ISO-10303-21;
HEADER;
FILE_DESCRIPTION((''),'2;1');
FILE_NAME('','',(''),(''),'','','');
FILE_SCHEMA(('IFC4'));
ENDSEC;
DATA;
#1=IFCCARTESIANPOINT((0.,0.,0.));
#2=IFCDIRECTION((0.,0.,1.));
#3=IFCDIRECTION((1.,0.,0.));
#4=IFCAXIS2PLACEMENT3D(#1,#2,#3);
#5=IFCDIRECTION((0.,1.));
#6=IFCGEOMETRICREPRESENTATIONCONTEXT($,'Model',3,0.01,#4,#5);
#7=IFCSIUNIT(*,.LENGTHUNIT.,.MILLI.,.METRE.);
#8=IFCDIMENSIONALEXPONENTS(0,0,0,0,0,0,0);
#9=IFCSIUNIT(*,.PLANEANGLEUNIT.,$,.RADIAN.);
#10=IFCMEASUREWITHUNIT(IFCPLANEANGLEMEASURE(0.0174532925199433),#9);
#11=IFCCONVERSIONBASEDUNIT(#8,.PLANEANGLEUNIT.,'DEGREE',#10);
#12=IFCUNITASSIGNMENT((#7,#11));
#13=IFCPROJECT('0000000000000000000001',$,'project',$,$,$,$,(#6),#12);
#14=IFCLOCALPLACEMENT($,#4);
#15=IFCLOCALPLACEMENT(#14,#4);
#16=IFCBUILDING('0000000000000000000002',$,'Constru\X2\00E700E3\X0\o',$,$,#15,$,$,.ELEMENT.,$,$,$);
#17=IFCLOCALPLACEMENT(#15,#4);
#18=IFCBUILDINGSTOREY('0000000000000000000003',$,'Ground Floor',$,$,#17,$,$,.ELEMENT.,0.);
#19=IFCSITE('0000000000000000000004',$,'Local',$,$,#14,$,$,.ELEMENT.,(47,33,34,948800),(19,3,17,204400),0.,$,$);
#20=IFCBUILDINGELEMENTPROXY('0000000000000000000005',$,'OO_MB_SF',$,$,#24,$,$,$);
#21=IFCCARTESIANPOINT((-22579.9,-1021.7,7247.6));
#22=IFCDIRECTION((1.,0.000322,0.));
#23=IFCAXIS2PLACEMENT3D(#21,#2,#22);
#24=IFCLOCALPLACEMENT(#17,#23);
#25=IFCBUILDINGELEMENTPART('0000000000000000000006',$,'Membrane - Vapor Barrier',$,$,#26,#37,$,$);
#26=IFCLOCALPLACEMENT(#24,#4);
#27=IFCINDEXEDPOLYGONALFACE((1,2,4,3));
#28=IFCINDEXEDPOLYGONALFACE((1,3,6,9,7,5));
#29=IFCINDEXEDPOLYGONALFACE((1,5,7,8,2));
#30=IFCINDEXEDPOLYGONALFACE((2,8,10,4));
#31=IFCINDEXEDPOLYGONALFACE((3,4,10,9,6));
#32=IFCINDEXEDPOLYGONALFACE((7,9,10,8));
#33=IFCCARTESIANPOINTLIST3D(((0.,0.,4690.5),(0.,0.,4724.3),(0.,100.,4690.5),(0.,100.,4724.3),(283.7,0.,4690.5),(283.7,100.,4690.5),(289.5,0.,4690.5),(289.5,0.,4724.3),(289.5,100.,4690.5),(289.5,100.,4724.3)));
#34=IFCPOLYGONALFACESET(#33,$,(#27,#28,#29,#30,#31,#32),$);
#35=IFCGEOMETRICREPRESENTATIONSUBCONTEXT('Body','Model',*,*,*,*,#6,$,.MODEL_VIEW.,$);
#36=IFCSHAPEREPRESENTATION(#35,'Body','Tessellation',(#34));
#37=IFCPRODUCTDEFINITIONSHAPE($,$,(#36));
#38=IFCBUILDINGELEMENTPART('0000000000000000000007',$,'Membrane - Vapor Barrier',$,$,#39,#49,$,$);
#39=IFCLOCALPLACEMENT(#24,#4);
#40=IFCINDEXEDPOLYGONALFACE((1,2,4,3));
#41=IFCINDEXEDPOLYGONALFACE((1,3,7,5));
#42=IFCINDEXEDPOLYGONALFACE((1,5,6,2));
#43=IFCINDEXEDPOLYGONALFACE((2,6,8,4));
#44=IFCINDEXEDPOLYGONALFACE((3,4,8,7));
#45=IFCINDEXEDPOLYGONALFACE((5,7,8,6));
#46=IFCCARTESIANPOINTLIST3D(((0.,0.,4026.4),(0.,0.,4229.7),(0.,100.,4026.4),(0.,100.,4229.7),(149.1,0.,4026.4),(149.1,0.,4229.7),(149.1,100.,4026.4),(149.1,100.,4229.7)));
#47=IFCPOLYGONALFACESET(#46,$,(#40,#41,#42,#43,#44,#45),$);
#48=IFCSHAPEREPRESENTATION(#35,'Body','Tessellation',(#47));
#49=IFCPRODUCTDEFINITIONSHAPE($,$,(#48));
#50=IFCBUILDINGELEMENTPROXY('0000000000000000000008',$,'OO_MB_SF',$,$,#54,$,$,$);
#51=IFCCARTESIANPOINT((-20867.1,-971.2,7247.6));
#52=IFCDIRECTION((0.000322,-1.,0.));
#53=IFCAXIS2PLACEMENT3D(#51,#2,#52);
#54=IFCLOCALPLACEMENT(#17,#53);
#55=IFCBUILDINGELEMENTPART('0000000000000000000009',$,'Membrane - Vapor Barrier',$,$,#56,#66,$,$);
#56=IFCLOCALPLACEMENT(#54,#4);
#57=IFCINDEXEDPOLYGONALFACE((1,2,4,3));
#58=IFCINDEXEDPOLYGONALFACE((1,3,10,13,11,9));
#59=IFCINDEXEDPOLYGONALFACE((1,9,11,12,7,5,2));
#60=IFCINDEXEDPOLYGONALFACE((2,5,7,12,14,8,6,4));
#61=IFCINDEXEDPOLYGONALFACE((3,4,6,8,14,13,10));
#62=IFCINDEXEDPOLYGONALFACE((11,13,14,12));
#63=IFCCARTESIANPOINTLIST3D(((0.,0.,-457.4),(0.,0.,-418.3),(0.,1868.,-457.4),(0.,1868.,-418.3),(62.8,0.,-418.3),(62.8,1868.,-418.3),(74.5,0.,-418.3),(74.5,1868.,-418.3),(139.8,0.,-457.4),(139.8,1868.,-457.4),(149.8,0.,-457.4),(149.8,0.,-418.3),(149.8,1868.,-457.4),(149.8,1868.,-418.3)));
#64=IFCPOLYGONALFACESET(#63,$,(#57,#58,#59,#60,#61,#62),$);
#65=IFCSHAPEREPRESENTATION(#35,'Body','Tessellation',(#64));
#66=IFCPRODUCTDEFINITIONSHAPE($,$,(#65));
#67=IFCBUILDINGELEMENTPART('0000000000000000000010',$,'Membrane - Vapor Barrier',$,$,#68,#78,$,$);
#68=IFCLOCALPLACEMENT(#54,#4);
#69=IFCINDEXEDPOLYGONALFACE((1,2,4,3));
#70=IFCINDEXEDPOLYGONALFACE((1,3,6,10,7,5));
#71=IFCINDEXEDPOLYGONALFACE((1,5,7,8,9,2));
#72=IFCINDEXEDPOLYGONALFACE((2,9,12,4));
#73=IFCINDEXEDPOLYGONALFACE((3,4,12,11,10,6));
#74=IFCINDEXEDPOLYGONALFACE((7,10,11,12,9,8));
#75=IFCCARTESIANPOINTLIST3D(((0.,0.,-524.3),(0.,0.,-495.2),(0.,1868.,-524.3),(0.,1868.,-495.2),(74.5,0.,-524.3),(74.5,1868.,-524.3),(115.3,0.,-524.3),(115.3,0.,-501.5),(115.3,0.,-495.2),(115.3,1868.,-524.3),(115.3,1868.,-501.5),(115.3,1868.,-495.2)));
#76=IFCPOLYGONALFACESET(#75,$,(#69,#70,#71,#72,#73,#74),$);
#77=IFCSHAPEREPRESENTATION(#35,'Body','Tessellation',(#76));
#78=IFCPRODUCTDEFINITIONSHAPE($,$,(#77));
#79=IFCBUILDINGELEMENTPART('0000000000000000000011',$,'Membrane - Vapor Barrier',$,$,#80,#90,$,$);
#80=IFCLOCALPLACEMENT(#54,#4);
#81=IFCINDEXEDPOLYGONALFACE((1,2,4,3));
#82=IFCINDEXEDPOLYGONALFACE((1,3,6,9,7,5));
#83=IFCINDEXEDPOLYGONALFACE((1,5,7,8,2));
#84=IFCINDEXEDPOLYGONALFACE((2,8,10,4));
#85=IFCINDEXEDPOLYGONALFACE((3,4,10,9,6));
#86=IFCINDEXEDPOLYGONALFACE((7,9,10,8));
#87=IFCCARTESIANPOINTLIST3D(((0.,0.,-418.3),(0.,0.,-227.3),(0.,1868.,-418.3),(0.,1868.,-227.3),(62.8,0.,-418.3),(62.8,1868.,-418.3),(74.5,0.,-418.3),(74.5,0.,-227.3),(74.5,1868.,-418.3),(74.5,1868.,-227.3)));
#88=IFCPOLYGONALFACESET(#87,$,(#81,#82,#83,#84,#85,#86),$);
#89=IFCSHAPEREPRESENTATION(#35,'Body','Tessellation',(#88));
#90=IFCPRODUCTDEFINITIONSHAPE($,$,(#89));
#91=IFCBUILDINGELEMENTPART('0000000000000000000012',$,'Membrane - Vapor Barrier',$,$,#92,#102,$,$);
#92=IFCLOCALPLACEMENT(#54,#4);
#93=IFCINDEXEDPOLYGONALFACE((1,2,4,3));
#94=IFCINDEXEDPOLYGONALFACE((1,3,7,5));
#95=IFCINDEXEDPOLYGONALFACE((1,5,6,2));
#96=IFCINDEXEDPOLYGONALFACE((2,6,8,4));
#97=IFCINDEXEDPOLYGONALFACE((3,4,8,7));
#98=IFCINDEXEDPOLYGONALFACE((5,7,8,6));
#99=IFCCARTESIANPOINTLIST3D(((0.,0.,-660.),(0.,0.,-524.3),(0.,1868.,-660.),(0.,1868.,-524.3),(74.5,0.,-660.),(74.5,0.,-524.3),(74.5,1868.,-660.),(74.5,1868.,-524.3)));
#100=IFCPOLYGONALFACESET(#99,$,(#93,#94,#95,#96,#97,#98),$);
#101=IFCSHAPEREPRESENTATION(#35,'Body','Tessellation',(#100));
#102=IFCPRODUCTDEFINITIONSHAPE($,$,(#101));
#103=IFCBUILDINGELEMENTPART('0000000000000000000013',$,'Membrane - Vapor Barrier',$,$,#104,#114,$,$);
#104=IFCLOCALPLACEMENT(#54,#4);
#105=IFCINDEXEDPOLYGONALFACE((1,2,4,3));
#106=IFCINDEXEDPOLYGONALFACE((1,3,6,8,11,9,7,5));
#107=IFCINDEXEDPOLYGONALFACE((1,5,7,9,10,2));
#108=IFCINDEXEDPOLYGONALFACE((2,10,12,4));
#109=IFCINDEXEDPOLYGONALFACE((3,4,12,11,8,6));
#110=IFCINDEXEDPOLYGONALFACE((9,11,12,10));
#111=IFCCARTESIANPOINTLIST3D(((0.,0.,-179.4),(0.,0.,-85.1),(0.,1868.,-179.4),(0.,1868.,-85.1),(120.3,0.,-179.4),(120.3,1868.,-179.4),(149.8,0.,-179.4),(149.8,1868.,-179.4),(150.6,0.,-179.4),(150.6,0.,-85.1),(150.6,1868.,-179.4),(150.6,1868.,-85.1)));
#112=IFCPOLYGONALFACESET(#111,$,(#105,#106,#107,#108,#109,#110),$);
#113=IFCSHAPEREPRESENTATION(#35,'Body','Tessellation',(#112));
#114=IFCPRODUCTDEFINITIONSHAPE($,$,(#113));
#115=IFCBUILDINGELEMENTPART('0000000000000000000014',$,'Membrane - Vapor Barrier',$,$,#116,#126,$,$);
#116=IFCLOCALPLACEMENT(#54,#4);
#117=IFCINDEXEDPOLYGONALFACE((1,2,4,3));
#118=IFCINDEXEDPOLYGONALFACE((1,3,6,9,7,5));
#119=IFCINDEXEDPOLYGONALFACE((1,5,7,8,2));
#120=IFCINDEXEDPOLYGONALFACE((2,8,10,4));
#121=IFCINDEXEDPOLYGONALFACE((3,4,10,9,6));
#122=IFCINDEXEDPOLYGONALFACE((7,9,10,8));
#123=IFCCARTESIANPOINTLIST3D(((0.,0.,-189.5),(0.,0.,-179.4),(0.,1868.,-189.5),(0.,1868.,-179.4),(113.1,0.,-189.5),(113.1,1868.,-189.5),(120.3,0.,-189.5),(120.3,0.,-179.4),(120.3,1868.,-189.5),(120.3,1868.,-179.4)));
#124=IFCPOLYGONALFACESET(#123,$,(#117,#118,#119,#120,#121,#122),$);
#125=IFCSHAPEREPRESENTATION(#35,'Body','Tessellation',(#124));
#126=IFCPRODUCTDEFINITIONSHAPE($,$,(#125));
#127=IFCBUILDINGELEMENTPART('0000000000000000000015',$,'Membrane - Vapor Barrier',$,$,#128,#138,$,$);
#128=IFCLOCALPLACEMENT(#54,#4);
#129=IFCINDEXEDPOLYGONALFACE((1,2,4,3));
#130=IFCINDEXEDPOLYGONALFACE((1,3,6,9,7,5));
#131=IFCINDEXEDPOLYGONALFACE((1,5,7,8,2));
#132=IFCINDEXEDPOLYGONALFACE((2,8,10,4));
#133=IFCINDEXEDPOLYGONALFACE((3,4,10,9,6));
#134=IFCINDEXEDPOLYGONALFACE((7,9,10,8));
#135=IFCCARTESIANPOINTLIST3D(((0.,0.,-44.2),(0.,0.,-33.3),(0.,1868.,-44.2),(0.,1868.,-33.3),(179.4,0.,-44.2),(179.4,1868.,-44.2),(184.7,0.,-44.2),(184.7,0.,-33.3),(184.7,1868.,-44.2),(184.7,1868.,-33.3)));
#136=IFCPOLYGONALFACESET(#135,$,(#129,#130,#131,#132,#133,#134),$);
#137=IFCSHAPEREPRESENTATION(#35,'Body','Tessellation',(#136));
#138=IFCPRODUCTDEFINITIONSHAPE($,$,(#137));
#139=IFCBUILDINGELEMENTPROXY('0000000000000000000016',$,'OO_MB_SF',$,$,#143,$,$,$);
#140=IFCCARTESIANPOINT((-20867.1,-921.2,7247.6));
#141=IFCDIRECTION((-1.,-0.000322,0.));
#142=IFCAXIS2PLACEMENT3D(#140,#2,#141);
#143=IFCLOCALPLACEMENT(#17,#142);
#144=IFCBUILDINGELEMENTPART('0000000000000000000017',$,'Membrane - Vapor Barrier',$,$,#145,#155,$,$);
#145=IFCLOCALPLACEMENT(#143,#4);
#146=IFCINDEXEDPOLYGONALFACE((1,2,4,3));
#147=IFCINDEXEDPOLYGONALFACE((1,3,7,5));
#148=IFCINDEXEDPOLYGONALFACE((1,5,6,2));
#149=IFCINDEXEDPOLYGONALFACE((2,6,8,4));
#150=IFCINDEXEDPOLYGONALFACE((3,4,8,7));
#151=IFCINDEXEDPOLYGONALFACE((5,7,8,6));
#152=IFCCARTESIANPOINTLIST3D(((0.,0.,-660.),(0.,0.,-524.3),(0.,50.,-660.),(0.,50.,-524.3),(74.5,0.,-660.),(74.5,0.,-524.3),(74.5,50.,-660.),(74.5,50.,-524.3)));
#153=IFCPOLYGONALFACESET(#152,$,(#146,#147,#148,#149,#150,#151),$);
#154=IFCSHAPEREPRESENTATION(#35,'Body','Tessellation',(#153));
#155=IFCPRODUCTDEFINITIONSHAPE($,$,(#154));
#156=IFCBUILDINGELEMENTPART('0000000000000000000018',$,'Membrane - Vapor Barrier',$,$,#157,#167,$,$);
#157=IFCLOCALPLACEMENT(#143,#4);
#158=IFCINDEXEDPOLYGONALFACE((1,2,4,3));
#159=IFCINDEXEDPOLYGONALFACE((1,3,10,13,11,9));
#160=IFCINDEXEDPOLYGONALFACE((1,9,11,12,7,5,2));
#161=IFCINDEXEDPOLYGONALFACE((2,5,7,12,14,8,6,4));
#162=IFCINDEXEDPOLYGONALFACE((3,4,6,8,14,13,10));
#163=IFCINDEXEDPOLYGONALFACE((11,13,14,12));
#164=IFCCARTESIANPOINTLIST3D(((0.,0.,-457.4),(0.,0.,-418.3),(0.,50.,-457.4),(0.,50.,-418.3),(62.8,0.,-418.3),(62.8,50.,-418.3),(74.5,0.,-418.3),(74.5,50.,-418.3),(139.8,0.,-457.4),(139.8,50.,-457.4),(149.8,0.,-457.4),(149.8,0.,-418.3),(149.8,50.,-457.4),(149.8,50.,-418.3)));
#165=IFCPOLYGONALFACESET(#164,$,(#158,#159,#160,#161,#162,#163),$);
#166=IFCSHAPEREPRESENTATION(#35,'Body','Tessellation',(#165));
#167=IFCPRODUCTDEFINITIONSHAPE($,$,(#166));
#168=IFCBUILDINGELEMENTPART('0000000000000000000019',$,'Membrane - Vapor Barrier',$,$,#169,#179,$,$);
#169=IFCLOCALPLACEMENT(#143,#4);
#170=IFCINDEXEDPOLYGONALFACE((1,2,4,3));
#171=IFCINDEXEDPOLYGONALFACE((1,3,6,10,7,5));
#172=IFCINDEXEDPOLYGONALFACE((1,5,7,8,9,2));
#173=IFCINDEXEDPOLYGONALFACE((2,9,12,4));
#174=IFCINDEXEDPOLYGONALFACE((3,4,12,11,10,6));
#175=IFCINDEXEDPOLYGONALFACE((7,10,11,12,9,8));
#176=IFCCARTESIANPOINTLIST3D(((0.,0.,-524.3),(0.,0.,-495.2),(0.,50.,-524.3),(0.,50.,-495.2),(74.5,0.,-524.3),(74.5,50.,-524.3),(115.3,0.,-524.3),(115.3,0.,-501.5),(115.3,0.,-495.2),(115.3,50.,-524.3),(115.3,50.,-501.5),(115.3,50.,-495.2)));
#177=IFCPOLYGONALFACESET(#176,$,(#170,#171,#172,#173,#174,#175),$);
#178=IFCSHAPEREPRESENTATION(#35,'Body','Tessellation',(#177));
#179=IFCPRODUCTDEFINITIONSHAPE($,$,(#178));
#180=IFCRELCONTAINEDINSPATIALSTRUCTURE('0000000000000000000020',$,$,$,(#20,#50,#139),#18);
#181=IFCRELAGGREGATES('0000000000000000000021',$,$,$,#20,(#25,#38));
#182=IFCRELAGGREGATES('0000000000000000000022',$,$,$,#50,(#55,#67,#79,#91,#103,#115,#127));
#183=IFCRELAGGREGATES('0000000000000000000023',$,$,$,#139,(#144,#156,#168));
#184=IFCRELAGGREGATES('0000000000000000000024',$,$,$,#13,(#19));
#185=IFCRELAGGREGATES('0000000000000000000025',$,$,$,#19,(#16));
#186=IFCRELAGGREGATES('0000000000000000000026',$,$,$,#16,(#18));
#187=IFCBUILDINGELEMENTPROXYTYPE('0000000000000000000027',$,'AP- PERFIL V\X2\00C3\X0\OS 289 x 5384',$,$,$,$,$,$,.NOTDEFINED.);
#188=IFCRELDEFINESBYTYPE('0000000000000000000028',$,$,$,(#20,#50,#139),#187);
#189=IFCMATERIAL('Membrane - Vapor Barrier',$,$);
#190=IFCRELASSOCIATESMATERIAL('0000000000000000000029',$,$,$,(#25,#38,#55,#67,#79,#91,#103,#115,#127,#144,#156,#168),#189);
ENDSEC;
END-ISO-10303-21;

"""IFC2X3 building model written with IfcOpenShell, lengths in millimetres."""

from ifc_helpers import new_model, entity, si_unit, converted_unit, direction, frame, origin_with_axes, place, context, subcontext, project, spatial, polyline, outline, extrude, material, type_object, element, aggregate, save


model = new_model("IFC2X3")

# Units and contexts
model_context = context("Model", 3, precision=0.01, world=origin_with_axes(), true_north=direction((0.0, 1.0)))
body_context = subcontext(model_context, "Body", "Model", "MODEL_VIEW")
ifc_project = project(units=[si_unit("LENGTHUNIT", "METRE", prefix="MILLI"), converted_unit("PLANEANGLEUNIT", "DEGREE", entity("IfcPlaneAngleMeasure", 0.0174532925199433), si_unit("PLANEANGLEUNIT", "RADIAN"), dimensions=[0, 0, 0, 0, 0, 0, 0])], contexts=[model_context])

# Site, building, storey
site_placement = place(None, origin_with_axes())
site = spatial("IfcSite", under=ifc_project, at=site_placement, Name="Local", CompositionType="ELEMENT", RefLatitude=(47, 33, 34, 948800), RefLongitude=(19, 3, 17, 204400), RefElevation=0.0)
building_placement = place(site_placement, origin_with_axes())
building = spatial("IfcBuilding", under=site, at=building_placement, Name="Construção", CompositionType="ELEMENT")
storey_placement = place(building_placement, origin_with_axes())
storey = spatial("IfcBuildingStorey", under=building, at=storey_placement, Name="Ground Floor", CompositionType="ELEMENT", Elevation=0.0)

# Building element proxies, building element parts
building_element_proxy_type = type_object("IfcBuildingElementProxyType", Name="AP- PERFIL VÃOS 289 x 5384", PredefinedType="NOTDEFINED")
proxy_1_placement = place(storey_placement, frame((-22579.9, -1021.7, 7247.6), z_axis=(0.0, 0.0, 1.0), x_axis=(1.0, 0.000322, 0.0)))
proxy_1 = element("IfcBuildingElementProxy", 1, at=proxy_1_placement, inside=storey, type_object=building_element_proxy_type, Name="OO_MB_SF")
ifc_material = material(Name="Membrane - Vapor Barrier")
building_element_part_1_placement = place(proxy_1_placement, origin_with_axes())
building_element_part_1 = element("IfcBuildingElementPart", 2, at=building_element_part_1_placement, material=ifc_material, Name="Membrane - Vapor Barrier", context=body_context, shape_type="SweptSolid", body=[
    extrude(outline(polyline([(0.0, 4690.5), (283.7, 4690.5), (289.5, 4690.5), (289.5, 4724.3), (0.0, 4724.3), (0.0, 4690.5)])), frame((0.0, 100.0, 0.0), z_axis=(0.0, -1.0, 0.0), x_axis=(1.0, 0.0, 0.0)), (0.0, 0.0, 1.0), 100.0),
])
building_element_part_2_placement = place(proxy_1_placement, origin_with_axes())
building_element_part_2 = element("IfcBuildingElementPart", 3, at=building_element_part_2_placement, material=ifc_material, Name="Membrane - Vapor Barrier", context=body_context, shape_type="SweptSolid", body=[
    extrude(outline(polyline([(149.1, 4229.7), (0.0, 4229.7), (0.0, 4026.4), (149.1, 4026.4), (149.1, 4229.7)])), frame((0.0, 100.0, 0.0), z_axis=(0.0, -1.0, 0.0), x_axis=(1.0, 0.0, 0.0)), (0.0, 0.0, 1.0), 100.0),
])
aggregate(proxy_1, [building_element_part_1, building_element_part_2])
proxy_2_placement = place(storey_placement, frame((-20867.1, -971.2, 7247.6), z_axis=(0.0, 0.0, 1.0), x_axis=(0.000322, -1.0, 0.0)))
proxy_2 = element("IfcBuildingElementProxy", 4, at=proxy_2_placement, inside=storey, type_object=building_element_proxy_type, Name="OO_MB_SF")
building_element_part_3_placement = place(proxy_2_placement, origin_with_axes())
building_element_part_3 = element("IfcBuildingElementPart", 5, at=building_element_part_3_placement, material=ifc_material, Name="Membrane - Vapor Barrier", context=body_context, shape_type="SweptSolid", body=[
    extrude(outline(polyline([(62.8, -418.3), (0.0, -418.3), (0.0, -457.4), (139.8, -457.4), (149.8, -457.4), (149.8, -418.3), (74.5, -418.3), (62.8, -418.3)])), frame((0.0, 1868.0, 0.0), z_axis=(0.0, -1.0, 0.0), x_axis=(1.0, 0.0, 0.0)), (0.0, 0.0, 1.0), 1868.0),
])
building_element_part_4_placement = place(proxy_2_placement, origin_with_axes())
building_element_part_4 = element("IfcBuildingElementPart", 6, at=building_element_part_4_placement, material=ifc_material, Name="Membrane - Vapor Barrier", context=body_context, shape_type="SweptSolid", body=[
    extrude(outline(polyline([(0.0, -524.3), (74.5, -524.3), (115.3, -524.3), (115.3, -501.5), (115.3, -495.2), (0.0, -495.2), (0.0, -524.3)])), frame((0.0, 1868.0, 0.0), z_axis=(0.0, -1.0, 0.0), x_axis=(1.0, 0.0, 0.0)), (0.0, 0.0, 1.0), 1868.0),
])
building_element_part_5_placement = place(proxy_2_placement, origin_with_axes())
building_element_part_5 = element("IfcBuildingElementPart", 7, at=building_element_part_5_placement, material=ifc_material, Name="Membrane - Vapor Barrier", context=body_context, shape_type="SweptSolid", body=[
    extrude(outline(polyline([(0.0, -227.3), (0.0, -418.3), (62.8, -418.3), (74.5, -418.3), (74.5, -227.3), (0.0, -227.3)])), frame((0.0, 1868.0, 0.0), z_axis=(0.0, -1.0, 0.0), x_axis=(1.0, 0.0, 0.0)), (0.0, 0.0, 1.0), 1868.0),
])
building_element_part_6_placement = place(proxy_2_placement, origin_with_axes())
building_element_part_6 = element("IfcBuildingElementPart", 8, at=building_element_part_6_placement, material=ifc_material, Name="Membrane - Vapor Barrier", context=body_context, shape_type="SweptSolid", body=[
    extrude(outline(polyline([(0.0, -660.0), (74.5, -660.0), (74.5, -524.3), (0.0, -524.3), (0.0, -660.0)])), frame((0.0, 1868.0, 0.0), z_axis=(0.0, -1.0, 0.0), x_axis=(1.0, 0.0, 0.0)), (0.0, 0.0, 1.0), 1868.0),
])
building_element_part_7_placement = place(proxy_2_placement, origin_with_axes())
building_element_part_7 = element("IfcBuildingElementPart", 9, at=building_element_part_7_placement, material=ifc_material, Name="Membrane - Vapor Barrier", context=body_context, shape_type="SweptSolid", body=[
    extrude(outline(polyline([(0.0, -85.1), (0.0, -179.4), (120.3, -179.4), (149.8, -179.4), (150.6, -179.4), (150.6, -85.1), (0.0, -85.1)])), frame((0.0, 1868.0, 0.0), z_axis=(0.0, -1.0, 0.0), x_axis=(1.0, 0.0, 0.0)), (0.0, 0.0, 1.0), 1868.0),
])
building_element_part_8_placement = place(proxy_2_placement, origin_with_axes())
building_element_part_8 = element("IfcBuildingElementPart", 10, at=building_element_part_8_placement, material=ifc_material, Name="Membrane - Vapor Barrier", context=body_context, shape_type="SweptSolid", body=[
    extrude(outline(polyline([(120.3, -179.4), (0.0, -179.4), (0.0, -189.5), (113.1, -189.5), (120.3, -189.5), (120.3, -179.4)])), frame((0.0, 1868.0, 0.0), z_axis=(0.0, -1.0, 0.0), x_axis=(1.0, 0.0, 0.0)), (0.0, 0.0, 1.0), 1868.0),
])
building_element_part_9_placement = place(proxy_2_placement, origin_with_axes())
building_element_part_9 = element("IfcBuildingElementPart", 11, at=building_element_part_9_placement, material=ifc_material, Name="Membrane - Vapor Barrier", context=body_context, shape_type="SweptSolid", body=[
    extrude(outline(polyline([(184.7, -33.3), (0.0, -33.3), (0.0, -44.2), (179.4, -44.2), (184.7, -44.2), (184.7, -33.3)])), frame((0.0, 1868.0, 0.0), z_axis=(0.0, -1.0, 0.0), x_axis=(1.0, 0.0, 0.0)), (0.0, 0.0, 1.0), 1868.0),
])
aggregate(proxy_2, [building_element_part_3, building_element_part_4, building_element_part_5, building_element_part_6, building_element_part_7, building_element_part_8, building_element_part_9])
proxy_3_placement = place(storey_placement, frame((-20867.1, -921.2, 7247.6), z_axis=(0.0, 0.0, 1.0), x_axis=(-1.0, -0.000322, 0.0)))
proxy_3 = element("IfcBuildingElementProxy", 12, at=proxy_3_placement, inside=storey, type_object=building_element_proxy_type, Name="OO_MB_SF")
building_element_part_10_placement = place(proxy_3_placement, origin_with_axes())
building_element_part_10 = element("IfcBuildingElementPart", 13, at=building_element_part_10_placement, material=ifc_material, Name="Membrane - Vapor Barrier", context=body_context, shape_type="SweptSolid", body=[
    extrude(outline(polyline([(0.0, -660.0), (74.5, -660.0), (74.5, -524.3), (0.0, -524.3), (0.0, -660.0)])), frame((0.0, 50.0, 0.0), z_axis=(0.0, -1.0, 0.0), x_axis=(1.0, 0.0, 0.0)), (0.0, 0.0, 1.0), 50.0),
])
building_element_part_11_placement = place(proxy_3_placement, origin_with_axes())
building_element_part_11 = element("IfcBuildingElementPart", 14, at=building_element_part_11_placement, material=ifc_material, Name="Membrane - Vapor Barrier", context=body_context, shape_type="SweptSolid", body=[
    extrude(outline(polyline([(62.8, -418.3), (0.0, -418.3), (0.0, -457.4), (139.8, -457.4), (149.8, -457.4), (149.8, -418.3), (74.5, -418.3), (62.8, -418.3)])), frame((0.0, 50.0, 0.0), z_axis=(0.0, -1.0, 0.0), x_axis=(1.0, 0.0, 0.0)), (0.0, 0.0, 1.0), 50.0),
])
building_element_part_12_placement = place(proxy_3_placement, origin_with_axes())
building_element_part_12 = element("IfcBuildingElementPart", 15, at=building_element_part_12_placement, material=ifc_material, Name="Membrane - Vapor Barrier", context=body_context, shape_type="SweptSolid", body=[
    extrude(outline(polyline([(0.0, -524.3), (74.5, -524.3), (115.3, -524.3), (115.3, -501.5), (115.3, -495.2), (0.0, -495.2), (0.0, -524.3)])), frame((0.0, 50.0, 0.0), z_axis=(0.0, -1.0, 0.0), x_axis=(1.0, 0.0, 0.0)), (0.0, 0.0, 1.0), 50.0),
])
aggregate(proxy_3, [building_element_part_10, building_element_part_11, building_element_part_12])

save(model, "model.ifc")
